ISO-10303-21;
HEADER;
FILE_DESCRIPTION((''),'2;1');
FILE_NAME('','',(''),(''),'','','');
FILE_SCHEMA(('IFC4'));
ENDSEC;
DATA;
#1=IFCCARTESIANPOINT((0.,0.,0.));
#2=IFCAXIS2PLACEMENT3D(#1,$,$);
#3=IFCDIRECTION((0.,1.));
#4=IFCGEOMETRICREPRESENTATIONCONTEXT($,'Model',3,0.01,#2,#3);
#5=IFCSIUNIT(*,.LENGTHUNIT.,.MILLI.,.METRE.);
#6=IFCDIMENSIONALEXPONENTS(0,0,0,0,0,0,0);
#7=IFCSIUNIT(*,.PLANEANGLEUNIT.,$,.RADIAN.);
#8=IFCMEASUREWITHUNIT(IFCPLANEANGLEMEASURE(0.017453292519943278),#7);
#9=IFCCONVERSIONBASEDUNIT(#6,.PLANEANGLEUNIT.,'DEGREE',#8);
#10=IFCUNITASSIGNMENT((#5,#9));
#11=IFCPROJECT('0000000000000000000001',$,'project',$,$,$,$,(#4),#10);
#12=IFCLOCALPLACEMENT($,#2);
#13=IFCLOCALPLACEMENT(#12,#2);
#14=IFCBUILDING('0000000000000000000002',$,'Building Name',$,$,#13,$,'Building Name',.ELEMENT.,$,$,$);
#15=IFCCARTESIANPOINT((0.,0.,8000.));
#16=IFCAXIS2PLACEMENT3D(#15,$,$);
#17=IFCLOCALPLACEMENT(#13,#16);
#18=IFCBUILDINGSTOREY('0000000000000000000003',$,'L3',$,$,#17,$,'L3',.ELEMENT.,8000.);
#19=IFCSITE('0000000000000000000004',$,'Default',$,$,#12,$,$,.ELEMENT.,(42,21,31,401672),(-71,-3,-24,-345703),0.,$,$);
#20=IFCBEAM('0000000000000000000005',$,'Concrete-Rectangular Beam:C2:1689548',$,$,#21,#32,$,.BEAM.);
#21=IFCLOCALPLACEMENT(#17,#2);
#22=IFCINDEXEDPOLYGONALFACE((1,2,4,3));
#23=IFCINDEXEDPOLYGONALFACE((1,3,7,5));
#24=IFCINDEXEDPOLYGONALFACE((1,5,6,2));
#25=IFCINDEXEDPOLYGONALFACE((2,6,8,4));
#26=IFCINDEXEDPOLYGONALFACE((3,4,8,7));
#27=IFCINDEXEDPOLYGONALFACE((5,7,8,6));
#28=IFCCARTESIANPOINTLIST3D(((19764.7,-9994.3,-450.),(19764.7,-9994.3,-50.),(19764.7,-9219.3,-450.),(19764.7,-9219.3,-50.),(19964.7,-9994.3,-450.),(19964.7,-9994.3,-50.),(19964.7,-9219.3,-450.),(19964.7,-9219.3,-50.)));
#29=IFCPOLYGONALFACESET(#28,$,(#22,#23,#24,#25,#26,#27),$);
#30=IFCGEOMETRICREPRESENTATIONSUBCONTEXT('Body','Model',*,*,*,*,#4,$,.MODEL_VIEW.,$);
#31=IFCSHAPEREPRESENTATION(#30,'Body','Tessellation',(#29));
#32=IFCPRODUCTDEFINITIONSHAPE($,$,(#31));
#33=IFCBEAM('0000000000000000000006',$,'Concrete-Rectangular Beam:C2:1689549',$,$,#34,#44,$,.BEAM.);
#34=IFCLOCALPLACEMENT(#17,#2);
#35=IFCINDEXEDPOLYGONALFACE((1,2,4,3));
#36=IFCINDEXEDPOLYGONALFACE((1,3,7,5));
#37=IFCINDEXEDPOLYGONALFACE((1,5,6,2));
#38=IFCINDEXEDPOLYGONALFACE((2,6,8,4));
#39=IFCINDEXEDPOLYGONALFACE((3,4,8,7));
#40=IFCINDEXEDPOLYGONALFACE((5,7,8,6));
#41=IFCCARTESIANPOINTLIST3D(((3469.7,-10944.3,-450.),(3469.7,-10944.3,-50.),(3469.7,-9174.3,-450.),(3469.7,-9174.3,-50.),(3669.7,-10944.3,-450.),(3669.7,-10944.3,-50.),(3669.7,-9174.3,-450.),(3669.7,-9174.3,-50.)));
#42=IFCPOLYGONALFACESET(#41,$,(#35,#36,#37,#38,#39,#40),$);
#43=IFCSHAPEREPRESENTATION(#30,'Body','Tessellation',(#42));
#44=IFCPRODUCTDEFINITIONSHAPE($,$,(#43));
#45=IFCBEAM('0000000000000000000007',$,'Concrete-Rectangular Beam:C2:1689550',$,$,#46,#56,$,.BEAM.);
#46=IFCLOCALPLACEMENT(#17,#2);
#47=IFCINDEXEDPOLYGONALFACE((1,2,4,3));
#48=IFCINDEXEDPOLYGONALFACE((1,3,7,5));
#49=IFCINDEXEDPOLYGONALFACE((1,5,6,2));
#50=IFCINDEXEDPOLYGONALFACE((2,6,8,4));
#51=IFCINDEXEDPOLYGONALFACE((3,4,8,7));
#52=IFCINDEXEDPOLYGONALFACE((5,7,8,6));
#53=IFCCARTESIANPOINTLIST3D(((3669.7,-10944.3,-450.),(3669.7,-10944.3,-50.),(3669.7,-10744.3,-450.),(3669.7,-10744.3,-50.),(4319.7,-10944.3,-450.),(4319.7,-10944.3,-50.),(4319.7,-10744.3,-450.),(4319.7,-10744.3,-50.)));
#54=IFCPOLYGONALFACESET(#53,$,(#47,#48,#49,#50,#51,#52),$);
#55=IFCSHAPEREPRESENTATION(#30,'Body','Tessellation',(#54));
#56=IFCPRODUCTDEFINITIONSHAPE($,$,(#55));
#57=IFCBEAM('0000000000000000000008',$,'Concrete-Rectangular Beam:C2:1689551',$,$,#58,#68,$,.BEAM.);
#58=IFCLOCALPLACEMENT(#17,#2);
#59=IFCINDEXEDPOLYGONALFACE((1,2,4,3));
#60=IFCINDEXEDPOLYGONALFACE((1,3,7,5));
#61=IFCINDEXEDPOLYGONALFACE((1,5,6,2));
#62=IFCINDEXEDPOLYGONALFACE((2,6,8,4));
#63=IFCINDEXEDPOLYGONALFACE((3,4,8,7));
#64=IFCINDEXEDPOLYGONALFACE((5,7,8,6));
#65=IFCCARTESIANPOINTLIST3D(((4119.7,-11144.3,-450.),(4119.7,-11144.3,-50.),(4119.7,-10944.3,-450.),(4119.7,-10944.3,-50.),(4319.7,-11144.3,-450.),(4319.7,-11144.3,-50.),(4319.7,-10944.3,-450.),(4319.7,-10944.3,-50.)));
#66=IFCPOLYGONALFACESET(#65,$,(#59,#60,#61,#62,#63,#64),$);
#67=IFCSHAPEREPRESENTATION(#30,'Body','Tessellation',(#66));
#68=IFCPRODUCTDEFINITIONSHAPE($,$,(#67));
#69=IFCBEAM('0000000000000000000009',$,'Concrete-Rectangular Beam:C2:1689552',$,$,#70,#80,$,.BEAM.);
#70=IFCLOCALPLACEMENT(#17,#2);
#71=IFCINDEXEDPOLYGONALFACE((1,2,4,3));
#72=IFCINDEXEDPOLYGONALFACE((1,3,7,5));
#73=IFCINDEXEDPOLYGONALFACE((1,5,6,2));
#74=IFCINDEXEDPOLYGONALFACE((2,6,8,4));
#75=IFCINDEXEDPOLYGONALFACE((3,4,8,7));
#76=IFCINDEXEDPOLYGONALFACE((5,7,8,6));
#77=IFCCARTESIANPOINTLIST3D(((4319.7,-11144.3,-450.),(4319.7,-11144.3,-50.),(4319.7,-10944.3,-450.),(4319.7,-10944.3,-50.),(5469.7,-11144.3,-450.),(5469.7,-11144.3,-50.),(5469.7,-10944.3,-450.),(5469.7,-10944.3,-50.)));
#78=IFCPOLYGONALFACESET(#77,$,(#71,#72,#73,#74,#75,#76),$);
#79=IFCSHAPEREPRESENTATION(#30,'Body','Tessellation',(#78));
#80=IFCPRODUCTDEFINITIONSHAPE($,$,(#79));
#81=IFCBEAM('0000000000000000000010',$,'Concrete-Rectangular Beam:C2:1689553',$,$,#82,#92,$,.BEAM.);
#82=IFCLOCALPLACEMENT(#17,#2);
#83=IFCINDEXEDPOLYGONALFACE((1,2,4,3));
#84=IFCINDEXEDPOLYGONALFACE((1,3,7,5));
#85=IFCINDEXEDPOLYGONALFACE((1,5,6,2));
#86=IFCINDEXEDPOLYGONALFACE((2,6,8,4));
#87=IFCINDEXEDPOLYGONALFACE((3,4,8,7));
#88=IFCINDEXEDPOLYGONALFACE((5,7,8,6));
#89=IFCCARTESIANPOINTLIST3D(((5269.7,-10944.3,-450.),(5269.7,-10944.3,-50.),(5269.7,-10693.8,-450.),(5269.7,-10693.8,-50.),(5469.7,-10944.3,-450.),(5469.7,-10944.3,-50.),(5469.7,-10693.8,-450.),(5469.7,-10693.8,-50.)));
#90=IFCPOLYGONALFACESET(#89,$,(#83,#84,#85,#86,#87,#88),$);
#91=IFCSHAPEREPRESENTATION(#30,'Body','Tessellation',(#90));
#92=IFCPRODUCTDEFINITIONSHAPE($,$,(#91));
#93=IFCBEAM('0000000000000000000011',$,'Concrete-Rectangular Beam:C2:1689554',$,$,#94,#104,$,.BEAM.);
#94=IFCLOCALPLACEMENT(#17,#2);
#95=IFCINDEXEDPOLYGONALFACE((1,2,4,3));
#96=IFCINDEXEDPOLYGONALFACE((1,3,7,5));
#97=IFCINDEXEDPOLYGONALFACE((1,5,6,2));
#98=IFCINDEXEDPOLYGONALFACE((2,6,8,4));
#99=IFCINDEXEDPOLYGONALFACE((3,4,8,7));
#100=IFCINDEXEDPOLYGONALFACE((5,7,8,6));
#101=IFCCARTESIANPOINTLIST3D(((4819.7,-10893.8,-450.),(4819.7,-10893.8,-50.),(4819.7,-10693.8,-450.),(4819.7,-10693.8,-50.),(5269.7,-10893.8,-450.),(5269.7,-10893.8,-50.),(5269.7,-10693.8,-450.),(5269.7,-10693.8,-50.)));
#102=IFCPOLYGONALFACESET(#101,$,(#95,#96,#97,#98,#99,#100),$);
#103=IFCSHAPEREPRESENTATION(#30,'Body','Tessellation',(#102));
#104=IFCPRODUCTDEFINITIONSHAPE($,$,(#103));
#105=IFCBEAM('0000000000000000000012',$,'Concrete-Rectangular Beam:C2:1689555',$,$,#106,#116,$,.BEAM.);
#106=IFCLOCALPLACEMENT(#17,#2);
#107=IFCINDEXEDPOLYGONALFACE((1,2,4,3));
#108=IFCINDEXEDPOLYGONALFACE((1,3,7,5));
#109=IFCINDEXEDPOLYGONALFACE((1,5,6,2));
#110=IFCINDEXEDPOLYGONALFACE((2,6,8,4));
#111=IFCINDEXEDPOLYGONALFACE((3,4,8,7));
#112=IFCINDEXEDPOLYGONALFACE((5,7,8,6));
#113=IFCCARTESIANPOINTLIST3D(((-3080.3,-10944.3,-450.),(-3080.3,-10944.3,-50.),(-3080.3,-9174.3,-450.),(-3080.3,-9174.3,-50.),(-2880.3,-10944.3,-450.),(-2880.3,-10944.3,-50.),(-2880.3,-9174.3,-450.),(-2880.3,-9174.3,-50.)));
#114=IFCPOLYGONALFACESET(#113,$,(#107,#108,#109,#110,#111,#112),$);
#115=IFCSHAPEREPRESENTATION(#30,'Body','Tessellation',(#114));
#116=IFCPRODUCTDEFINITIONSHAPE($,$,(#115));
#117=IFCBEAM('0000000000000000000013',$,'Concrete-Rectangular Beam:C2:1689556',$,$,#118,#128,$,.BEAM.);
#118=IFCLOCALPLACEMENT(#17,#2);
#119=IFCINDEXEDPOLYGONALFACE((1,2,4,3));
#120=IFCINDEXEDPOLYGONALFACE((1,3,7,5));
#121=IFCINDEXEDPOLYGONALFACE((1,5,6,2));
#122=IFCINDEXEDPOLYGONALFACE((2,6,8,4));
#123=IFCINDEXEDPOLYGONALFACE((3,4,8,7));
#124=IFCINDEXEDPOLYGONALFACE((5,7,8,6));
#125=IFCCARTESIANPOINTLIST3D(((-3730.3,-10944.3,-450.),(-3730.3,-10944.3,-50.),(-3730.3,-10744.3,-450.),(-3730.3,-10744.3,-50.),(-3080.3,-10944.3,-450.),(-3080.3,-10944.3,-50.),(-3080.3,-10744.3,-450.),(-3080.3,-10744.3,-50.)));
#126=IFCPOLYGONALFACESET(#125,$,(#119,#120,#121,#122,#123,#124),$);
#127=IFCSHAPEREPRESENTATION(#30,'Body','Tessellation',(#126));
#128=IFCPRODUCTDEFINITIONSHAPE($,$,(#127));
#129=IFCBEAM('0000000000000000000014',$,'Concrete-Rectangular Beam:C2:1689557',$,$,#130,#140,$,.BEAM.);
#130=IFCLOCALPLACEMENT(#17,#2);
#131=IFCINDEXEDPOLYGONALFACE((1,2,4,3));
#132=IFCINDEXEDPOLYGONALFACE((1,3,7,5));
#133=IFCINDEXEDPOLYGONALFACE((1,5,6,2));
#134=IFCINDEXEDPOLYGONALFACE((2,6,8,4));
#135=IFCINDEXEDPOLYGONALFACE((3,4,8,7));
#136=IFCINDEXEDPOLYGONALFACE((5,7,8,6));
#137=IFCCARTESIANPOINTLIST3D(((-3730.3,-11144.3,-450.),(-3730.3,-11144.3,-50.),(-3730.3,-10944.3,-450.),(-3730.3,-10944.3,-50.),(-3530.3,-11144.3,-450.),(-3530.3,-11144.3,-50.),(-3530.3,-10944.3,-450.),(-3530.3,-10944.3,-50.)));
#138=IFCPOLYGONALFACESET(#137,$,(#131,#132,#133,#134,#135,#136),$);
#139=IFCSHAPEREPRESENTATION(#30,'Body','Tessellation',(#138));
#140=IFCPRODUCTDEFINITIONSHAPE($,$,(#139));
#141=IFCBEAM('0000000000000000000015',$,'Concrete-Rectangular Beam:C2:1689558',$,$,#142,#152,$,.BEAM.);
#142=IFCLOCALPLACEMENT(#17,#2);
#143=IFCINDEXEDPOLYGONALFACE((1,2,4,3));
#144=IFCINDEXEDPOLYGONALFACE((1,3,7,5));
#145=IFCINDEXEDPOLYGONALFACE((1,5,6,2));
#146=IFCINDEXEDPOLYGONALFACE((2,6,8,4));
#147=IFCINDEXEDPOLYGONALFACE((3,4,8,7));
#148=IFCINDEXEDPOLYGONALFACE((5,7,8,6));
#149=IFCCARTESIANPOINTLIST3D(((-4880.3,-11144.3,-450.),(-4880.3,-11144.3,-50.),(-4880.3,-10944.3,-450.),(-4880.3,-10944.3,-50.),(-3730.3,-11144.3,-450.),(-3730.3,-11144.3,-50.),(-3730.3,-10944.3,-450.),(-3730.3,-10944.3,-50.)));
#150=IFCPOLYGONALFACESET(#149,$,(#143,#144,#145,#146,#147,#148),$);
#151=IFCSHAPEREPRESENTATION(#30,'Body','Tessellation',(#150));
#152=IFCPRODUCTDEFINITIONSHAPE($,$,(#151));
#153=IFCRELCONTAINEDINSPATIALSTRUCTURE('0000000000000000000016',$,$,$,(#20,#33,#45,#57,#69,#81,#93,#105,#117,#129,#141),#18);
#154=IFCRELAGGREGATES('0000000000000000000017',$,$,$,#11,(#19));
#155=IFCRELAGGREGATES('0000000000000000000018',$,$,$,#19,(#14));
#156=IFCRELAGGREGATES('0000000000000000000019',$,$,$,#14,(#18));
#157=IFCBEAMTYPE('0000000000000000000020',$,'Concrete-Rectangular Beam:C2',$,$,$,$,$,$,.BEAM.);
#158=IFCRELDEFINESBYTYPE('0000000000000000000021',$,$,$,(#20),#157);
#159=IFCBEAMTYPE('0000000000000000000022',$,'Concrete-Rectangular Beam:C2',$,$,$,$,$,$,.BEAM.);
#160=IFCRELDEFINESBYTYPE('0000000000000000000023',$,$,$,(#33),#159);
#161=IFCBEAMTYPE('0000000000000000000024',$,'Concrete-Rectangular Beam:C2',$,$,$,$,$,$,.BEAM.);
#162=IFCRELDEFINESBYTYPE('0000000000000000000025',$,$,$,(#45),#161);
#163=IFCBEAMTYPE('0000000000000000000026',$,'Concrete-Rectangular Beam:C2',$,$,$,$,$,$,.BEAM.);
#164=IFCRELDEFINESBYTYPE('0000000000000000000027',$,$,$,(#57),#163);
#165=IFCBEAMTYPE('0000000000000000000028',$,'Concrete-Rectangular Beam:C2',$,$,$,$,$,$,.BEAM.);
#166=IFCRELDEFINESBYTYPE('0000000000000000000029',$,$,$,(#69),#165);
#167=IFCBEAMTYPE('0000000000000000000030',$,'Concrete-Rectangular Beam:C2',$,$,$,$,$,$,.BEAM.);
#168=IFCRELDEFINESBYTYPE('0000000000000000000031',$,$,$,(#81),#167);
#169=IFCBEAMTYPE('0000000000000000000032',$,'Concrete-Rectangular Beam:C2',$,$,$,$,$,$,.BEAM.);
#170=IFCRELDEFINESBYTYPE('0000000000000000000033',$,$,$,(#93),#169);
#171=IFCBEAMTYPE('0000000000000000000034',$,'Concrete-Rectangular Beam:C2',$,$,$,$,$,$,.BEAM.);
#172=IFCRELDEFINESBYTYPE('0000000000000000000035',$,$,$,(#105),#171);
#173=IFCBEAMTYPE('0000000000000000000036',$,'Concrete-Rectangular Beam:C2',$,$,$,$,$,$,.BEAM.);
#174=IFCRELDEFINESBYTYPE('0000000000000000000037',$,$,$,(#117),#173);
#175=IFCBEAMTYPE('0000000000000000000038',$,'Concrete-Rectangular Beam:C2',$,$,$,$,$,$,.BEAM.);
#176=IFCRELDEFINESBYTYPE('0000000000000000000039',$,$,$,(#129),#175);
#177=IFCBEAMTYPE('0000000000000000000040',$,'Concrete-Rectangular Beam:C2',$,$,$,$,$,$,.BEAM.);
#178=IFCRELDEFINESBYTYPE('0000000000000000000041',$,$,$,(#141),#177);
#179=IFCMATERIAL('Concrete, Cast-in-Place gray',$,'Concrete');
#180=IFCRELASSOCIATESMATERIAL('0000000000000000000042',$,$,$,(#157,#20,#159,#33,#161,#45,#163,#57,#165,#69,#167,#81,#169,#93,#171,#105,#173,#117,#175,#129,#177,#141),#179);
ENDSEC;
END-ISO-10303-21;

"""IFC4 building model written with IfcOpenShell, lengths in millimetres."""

from ifc_helpers import new_model, entity, si_unit, converted_unit, direction, frame, origin, place, context, subcontext, project, spatial, indexed_curve, outline, extrude, source, transform, mapped, material, type_object, type_shapes, element, save


model = new_model("IFC4")

# Units and contexts
model_context = context("Model", 3, precision=0.01, world=origin(), true_north=direction((0.0, 1.0)))
body_context = subcontext(model_context, "Body", "Model", "MODEL_VIEW")
ifc_project = project(units=[si_unit("LENGTHUNIT", "METRE", prefix="MILLI"), converted_unit("PLANEANGLEUNIT", "DEGREE", entity("IfcPlaneAngleMeasure", 0.017453292519943278), si_unit("PLANEANGLEUNIT", "RADIAN"), dimensions=[0, 0, 0, 0, 0, 0, 0])], contexts=[model_context])

# Site, building, storey
site_placement = place(None, origin())
site = spatial("IfcSite", under=ifc_project, at=site_placement, Name="Default", CompositionType="ELEMENT", RefLatitude=(42, 21, 31, 401672), RefLongitude=(-71, -3, -24, -345703), RefElevation=0.0)
building_placement = place(site_placement, origin())
building = spatial("IfcBuilding", under=site, at=building_placement, Name="Building Name", LongName="Building Name", CompositionType="ELEMENT")
storey_placement = place(building_placement, frame((0.0, 0.0, 8000.0)))
storey = spatial("IfcBuildingStorey", under=building, at=storey_placement, Name="L3", LongName="L3", CompositionType="ELEMENT", Elevation=8000.0)

# Beams
ifc_material = material(Name="Concrete, Cast-in-Place gray", Category="Concrete")
beam_type_1 = type_object("IfcBeamType", Name="Concrete-Rectangular Beam:C2", PredefinedType="BEAM", material=ifc_material)
shared_shape_1 = source(origin(), body_context, "Body", "SweptSolid", [
    extrude(outline(indexed_curve([(-100.0, -200.0), (100.0, -200.0), (100.0, 200.0), (-100.0, 200.0), (-100.0, -200.0)], self_intersect=False)), frame((19864.7, -9994.3, 7750.0), z_axis=(0.0, 1.0, 0.0), x_axis=(-1.0, 0.0, 0.0)), (0.0, 0.0, 1.0), 775.0),
])
type_shapes(beam_type_1, [shared_shape_1])
beam_1_placement = place(storey_placement, frame((0.0, 0.0, -8000.0)))
element("IfcBeam", 1, at=beam_1_placement, inside=storey, type_object=beam_type_1, material=ifc_material, Name="Concrete-Rectangular Beam:C2:1689548", PredefinedType="BEAM", context=body_context, shape_type="MappedRepresentation", body=[
    mapped(shared_shape_1, transform((0.0, 0.0, 0.0), scale=1.0)),
])
beam_type_2 = type_object("IfcBeamType", Name="Concrete-Rectangular Beam:C2", PredefinedType="BEAM", material=ifc_material)
shared_shape_2 = source(origin(), body_context, "Body", "SweptSolid", [
    extrude(outline(indexed_curve([(-100.0, -200.0), (100.0, -200.0), (100.0, 200.0), (-100.0, 200.0), (-100.0, -200.0)], self_intersect=False)), frame((3569.7, -9174.3, 7750.0), z_axis=(0.0, -1.0, 0.0), x_axis=(-1.0, 0.0, 0.0)), (0.0, 0.0, 1.0), 1770.0),
])
type_shapes(beam_type_2, [shared_shape_2])
beam_2_placement = place(storey_placement, frame((0.0, 0.0, -8000.0)))
element("IfcBeam", 2, at=beam_2_placement, inside=storey, type_object=beam_type_2, material=ifc_material, Name="Concrete-Rectangular Beam:C2:1689549", PredefinedType="BEAM", context=body_context, shape_type="MappedRepresentation", body=[
    mapped(shared_shape_2, transform((0.0, 0.0, 0.0), scale=1.0)),
])
beam_type_3 = type_object("IfcBeamType", Name="Concrete-Rectangular Beam:C2", PredefinedType="BEAM", material=ifc_material)
shared_shape_3 = source(origin(), body_context, "Body", "SweptSolid", [
    extrude(outline(indexed_curve([(-200.0, -100.0), (200.0, -100.0), (200.0, 100.0), (-200.0, 100.0), (-200.0, -100.0)], self_intersect=False)), frame((3669.7, -10844.3, 7750.0), z_axis=(1.0, 0.0, 0.0), x_axis=(0.0, 0.0, -1.0)), (0.0, 0.0, 1.0), 650.0),
])
type_shapes(beam_type_3, [shared_shape_3])
beam_3_placement = place(storey_placement, frame((0.0, 0.0, -8000.0)))
element("IfcBeam", 3, at=beam_3_placement, inside=storey, type_object=beam_type_3, material=ifc_material, Name="Concrete-Rectangular Beam:C2:1689550", PredefinedType="BEAM", context=body_context, shape_type="MappedRepresentation", body=[
    mapped(shared_shape_3, transform((0.0, 0.0, 0.0), scale=1.0)),
])
beam_type_4 = type_object("IfcBeamType", Name="Concrete-Rectangular Beam:C2", PredefinedType="BEAM", material=ifc_material)
shared_shape_4 = source(origin(), body_context, "Body", "SweptSolid", [
    extrude(outline(indexed_curve([(-100.0, -200.0), (100.0, -200.0), (100.0, 200.0), (-100.0, 200.0), (-100.0, -200.0)], self_intersect=False)), frame((4219.7, -10944.3, 7750.0), z_axis=(0.0, -1.0, 0.0), x_axis=(-1.0, 0.0, 0.0)), (0.0, 0.0, 1.0), 200.0),
])
type_shapes(beam_type_4, [shared_shape_4])
beam_4_placement = place(storey_placement, frame((0.0, 0.0, -8000.0)))
element("IfcBeam", 4, at=beam_4_placement, inside=storey, type_object=beam_type_4, material=ifc_material, Name="Concrete-Rectangular Beam:C2:1689551", PredefinedType="BEAM", context=body_context, shape_type="MappedRepresentation", body=[
    mapped(shared_shape_4, transform((0.0, 0.0, 0.0), scale=1.0)),
])
beam_type_5 = type_object("IfcBeamType", Name="Concrete-Rectangular Beam:C2", PredefinedType="BEAM", material=ifc_material)
shared_shape_5 = source(origin(), body_context, "Body", "SweptSolid", [
    extrude(outline(indexed_curve([(-200.0, -100.0), (200.0, -100.0), (200.0, 100.0), (-200.0, 100.0), (-200.0, -100.0)], self_intersect=False)), frame((4319.7, -11044.3, 7750.0), z_axis=(1.0, 0.0, 0.0), x_axis=(0.0, 0.0, -1.0)), (0.0, 0.0, 1.0), 1150.0),
])
type_shapes(beam_type_5, [shared_shape_5])
beam_5_placement = place(storey_placement, frame((0.0, 0.0, -8000.0)))
element("IfcBeam", 5, at=beam_5_placement, inside=storey, type_object=beam_type_5, material=ifc_material, Name="Concrete-Rectangular Beam:C2:1689552", PredefinedType="BEAM", context=body_context, shape_type="MappedRepresentation", body=[
    mapped(shared_shape_5, transform((0.0, 0.0, 0.0), scale=1.0)),
])
beam_type_6 = type_object("IfcBeamType", Name="Concrete-Rectangular Beam:C2", PredefinedType="BEAM", material=ifc_material)
shared_shape_6 = source(origin(), body_context, "Body", "SweptSolid", [
    extrude(outline(indexed_curve([(-100.0, -200.0), (100.0, -200.0), (100.0, 200.0), (-100.0, 200.0), (-100.0, -200.0)], self_intersect=False)), frame((5369.7, -10944.3, 7750.0), z_axis=(0.0, 1.0, 0.0), x_axis=(-1.0, 0.0, 0.0)), (0.0, 0.0, 1.0), 250.5),
])
type_shapes(beam_type_6, [shared_shape_6])
beam_6_placement = place(storey_placement, frame((0.0, 0.0, -8000.0)))
element("IfcBeam", 6, at=beam_6_placement, inside=storey, type_object=beam_type_6, material=ifc_material, Name="Concrete-Rectangular Beam:C2:1689553", PredefinedType="BEAM", context=body_context, shape_type="MappedRepresentation", body=[
    mapped(shared_shape_6, transform((0.0, 0.0, 0.0), scale=1.0)),
])
beam_type_7 = type_object("IfcBeamType", Name="Concrete-Rectangular Beam:C2", PredefinedType="BEAM", material=ifc_material)
shared_shape_7 = source(origin(), body_context, "Body", "SweptSolid", [
    extrude(outline(indexed_curve([(-200.0, -100.0), (200.0, -100.0), (200.0, 100.0), (-200.0, 100.0), (-200.0, -100.0)], self_intersect=False)), frame((5269.7, -10793.8, 7750.0), z_axis=(-1.0, 0.0, 0.0), x_axis=(0.0, 0.0, -1.0)), (0.0, 0.0, 1.0), 450.0),
])
type_shapes(beam_type_7, [shared_shape_7])
beam_7_placement = place(storey_placement, frame((0.0, 0.0, -8000.0)))
element("IfcBeam", 7, at=beam_7_placement, inside=storey, type_object=beam_type_7, material=ifc_material, Name="Concrete-Rectangular Beam:C2:1689554", PredefinedType="BEAM", context=body_context, shape_type="MappedRepresentation", body=[
    mapped(shared_shape_7, transform((0.0, 0.0, 0.0), scale=1.0)),
])
beam_type_8 = type_object("IfcBeamType", Name="Concrete-Rectangular Beam:C2", PredefinedType="BEAM", material=ifc_material)
shared_shape_8 = source(origin(), body_context, "Body", "SweptSolid", [
    extrude(outline(indexed_curve([(-100.0, -200.0), (100.0, -200.0), (100.0, 200.0), (-100.0, 200.0), (-100.0, -200.0)], self_intersect=False)), frame((-2980.3, -9174.3, 7750.0), z_axis=(0.0, -1.0, 0.0), x_axis=(-1.0, 0.0, 0.0)), (0.0, 0.0, 1.0), 1770.0),
])
type_shapes(beam_type_8, [shared_shape_8])
beam_8_placement = place(storey_placement, frame((0.0, 0.0, -8000.0)))
element("IfcBeam", 8, at=beam_8_placement, inside=storey, type_object=beam_type_8, material=ifc_material, Name="Concrete-Rectangular Beam:C2:1689555", PredefinedType="BEAM", context=body_context, shape_type="MappedRepresentation", body=[
    mapped(shared_shape_8, transform((0.0, 0.0, 0.0), scale=1.0)),
])
beam_type_9 = type_object("IfcBeamType", Name="Concrete-Rectangular Beam:C2", PredefinedType="BEAM", material=ifc_material)
shared_shape_9 = source(origin(), body_context, "Body", "SweptSolid", [
    extrude(outline(indexed_curve([(-200.0, -100.0), (200.0, -100.0), (200.0, 100.0), (-200.0, 100.0), (-200.0, -100.0)], self_intersect=False)), frame((-3080.3, -10844.3, 7750.0), z_axis=(-1.0, 0.0, 0.0), x_axis=(0.0, 0.0, -1.0)), (0.0, 0.0, 1.0), 650.0),
])
type_shapes(beam_type_9, [shared_shape_9])
beam_9_placement = place(storey_placement, frame((0.0, 0.0, -8000.0)))
element("IfcBeam", 9, at=beam_9_placement, inside=storey, type_object=beam_type_9, material=ifc_material, Name="Concrete-Rectangular Beam:C2:1689556", PredefinedType="BEAM", context=body_context, shape_type="MappedRepresentation", body=[
    mapped(shared_shape_9, transform((0.0, 0.0, 0.0), scale=1.0)),
])
beam_type_10 = type_object("IfcBeamType", Name="Concrete-Rectangular Beam:C2", PredefinedType="BEAM", material=ifc_material)
shared_shape_10 = source(origin(), body_context, "Body", "SweptSolid", [
    extrude(outline(indexed_curve([(-100.0, -200.0), (100.0, -200.0), (100.0, 200.0), (-100.0, 200.0), (-100.0, -200.0)], self_intersect=False)), frame((-3630.3, -10944.3, 7750.0), z_axis=(0.0, -1.0, 0.0), x_axis=(-1.0, 0.0, 0.0)), (0.0, 0.0, 1.0), 200.0),
])
type_shapes(beam_type_10, [shared_shape_10])
beam_10_placement = place(storey_placement, frame((0.0, 0.0, -8000.0)))
element("IfcBeam", 10, at=beam_10_placement, inside=storey, type_object=beam_type_10, material=ifc_material, Name="Concrete-Rectangular Beam:C2:1689557", PredefinedType="BEAM", context=body_context, shape_type="MappedRepresentation", body=[
    mapped(shared_shape_10, transform((0.0, 0.0, 0.0), scale=1.0)),
])
beam_type_11 = type_object("IfcBeamType", Name="Concrete-Rectangular Beam:C2", PredefinedType="BEAM", material=ifc_material)
shared_shape_11 = source(origin(), body_context, "Body", "SweptSolid", [
    extrude(outline(indexed_curve([(-200.0, -100.0), (200.0, -100.0), (200.0, 100.0), (-200.0, 100.0), (-200.0, -100.0)], self_intersect=False)), frame((-3730.3, -11044.3, 7750.0), z_axis=(-1.0, 0.0, 0.0), x_axis=(0.0, 0.0, -1.0)), (0.0, 0.0, 1.0), 1150.0),
])
type_shapes(beam_type_11, [shared_shape_11])
beam_11_placement = place(storey_placement, frame((0.0, 0.0, -8000.0)))
element("IfcBeam", 11, at=beam_11_placement, inside=storey, type_object=beam_type_11, material=ifc_material, Name="Concrete-Rectangular Beam:C2:1689558", PredefinedType="BEAM", context=body_context, shape_type="MappedRepresentation", body=[
    mapped(shared_shape_11, transform((0.0, 0.0, 0.0), scale=1.0)),
])

save(model, "model.ifc")
